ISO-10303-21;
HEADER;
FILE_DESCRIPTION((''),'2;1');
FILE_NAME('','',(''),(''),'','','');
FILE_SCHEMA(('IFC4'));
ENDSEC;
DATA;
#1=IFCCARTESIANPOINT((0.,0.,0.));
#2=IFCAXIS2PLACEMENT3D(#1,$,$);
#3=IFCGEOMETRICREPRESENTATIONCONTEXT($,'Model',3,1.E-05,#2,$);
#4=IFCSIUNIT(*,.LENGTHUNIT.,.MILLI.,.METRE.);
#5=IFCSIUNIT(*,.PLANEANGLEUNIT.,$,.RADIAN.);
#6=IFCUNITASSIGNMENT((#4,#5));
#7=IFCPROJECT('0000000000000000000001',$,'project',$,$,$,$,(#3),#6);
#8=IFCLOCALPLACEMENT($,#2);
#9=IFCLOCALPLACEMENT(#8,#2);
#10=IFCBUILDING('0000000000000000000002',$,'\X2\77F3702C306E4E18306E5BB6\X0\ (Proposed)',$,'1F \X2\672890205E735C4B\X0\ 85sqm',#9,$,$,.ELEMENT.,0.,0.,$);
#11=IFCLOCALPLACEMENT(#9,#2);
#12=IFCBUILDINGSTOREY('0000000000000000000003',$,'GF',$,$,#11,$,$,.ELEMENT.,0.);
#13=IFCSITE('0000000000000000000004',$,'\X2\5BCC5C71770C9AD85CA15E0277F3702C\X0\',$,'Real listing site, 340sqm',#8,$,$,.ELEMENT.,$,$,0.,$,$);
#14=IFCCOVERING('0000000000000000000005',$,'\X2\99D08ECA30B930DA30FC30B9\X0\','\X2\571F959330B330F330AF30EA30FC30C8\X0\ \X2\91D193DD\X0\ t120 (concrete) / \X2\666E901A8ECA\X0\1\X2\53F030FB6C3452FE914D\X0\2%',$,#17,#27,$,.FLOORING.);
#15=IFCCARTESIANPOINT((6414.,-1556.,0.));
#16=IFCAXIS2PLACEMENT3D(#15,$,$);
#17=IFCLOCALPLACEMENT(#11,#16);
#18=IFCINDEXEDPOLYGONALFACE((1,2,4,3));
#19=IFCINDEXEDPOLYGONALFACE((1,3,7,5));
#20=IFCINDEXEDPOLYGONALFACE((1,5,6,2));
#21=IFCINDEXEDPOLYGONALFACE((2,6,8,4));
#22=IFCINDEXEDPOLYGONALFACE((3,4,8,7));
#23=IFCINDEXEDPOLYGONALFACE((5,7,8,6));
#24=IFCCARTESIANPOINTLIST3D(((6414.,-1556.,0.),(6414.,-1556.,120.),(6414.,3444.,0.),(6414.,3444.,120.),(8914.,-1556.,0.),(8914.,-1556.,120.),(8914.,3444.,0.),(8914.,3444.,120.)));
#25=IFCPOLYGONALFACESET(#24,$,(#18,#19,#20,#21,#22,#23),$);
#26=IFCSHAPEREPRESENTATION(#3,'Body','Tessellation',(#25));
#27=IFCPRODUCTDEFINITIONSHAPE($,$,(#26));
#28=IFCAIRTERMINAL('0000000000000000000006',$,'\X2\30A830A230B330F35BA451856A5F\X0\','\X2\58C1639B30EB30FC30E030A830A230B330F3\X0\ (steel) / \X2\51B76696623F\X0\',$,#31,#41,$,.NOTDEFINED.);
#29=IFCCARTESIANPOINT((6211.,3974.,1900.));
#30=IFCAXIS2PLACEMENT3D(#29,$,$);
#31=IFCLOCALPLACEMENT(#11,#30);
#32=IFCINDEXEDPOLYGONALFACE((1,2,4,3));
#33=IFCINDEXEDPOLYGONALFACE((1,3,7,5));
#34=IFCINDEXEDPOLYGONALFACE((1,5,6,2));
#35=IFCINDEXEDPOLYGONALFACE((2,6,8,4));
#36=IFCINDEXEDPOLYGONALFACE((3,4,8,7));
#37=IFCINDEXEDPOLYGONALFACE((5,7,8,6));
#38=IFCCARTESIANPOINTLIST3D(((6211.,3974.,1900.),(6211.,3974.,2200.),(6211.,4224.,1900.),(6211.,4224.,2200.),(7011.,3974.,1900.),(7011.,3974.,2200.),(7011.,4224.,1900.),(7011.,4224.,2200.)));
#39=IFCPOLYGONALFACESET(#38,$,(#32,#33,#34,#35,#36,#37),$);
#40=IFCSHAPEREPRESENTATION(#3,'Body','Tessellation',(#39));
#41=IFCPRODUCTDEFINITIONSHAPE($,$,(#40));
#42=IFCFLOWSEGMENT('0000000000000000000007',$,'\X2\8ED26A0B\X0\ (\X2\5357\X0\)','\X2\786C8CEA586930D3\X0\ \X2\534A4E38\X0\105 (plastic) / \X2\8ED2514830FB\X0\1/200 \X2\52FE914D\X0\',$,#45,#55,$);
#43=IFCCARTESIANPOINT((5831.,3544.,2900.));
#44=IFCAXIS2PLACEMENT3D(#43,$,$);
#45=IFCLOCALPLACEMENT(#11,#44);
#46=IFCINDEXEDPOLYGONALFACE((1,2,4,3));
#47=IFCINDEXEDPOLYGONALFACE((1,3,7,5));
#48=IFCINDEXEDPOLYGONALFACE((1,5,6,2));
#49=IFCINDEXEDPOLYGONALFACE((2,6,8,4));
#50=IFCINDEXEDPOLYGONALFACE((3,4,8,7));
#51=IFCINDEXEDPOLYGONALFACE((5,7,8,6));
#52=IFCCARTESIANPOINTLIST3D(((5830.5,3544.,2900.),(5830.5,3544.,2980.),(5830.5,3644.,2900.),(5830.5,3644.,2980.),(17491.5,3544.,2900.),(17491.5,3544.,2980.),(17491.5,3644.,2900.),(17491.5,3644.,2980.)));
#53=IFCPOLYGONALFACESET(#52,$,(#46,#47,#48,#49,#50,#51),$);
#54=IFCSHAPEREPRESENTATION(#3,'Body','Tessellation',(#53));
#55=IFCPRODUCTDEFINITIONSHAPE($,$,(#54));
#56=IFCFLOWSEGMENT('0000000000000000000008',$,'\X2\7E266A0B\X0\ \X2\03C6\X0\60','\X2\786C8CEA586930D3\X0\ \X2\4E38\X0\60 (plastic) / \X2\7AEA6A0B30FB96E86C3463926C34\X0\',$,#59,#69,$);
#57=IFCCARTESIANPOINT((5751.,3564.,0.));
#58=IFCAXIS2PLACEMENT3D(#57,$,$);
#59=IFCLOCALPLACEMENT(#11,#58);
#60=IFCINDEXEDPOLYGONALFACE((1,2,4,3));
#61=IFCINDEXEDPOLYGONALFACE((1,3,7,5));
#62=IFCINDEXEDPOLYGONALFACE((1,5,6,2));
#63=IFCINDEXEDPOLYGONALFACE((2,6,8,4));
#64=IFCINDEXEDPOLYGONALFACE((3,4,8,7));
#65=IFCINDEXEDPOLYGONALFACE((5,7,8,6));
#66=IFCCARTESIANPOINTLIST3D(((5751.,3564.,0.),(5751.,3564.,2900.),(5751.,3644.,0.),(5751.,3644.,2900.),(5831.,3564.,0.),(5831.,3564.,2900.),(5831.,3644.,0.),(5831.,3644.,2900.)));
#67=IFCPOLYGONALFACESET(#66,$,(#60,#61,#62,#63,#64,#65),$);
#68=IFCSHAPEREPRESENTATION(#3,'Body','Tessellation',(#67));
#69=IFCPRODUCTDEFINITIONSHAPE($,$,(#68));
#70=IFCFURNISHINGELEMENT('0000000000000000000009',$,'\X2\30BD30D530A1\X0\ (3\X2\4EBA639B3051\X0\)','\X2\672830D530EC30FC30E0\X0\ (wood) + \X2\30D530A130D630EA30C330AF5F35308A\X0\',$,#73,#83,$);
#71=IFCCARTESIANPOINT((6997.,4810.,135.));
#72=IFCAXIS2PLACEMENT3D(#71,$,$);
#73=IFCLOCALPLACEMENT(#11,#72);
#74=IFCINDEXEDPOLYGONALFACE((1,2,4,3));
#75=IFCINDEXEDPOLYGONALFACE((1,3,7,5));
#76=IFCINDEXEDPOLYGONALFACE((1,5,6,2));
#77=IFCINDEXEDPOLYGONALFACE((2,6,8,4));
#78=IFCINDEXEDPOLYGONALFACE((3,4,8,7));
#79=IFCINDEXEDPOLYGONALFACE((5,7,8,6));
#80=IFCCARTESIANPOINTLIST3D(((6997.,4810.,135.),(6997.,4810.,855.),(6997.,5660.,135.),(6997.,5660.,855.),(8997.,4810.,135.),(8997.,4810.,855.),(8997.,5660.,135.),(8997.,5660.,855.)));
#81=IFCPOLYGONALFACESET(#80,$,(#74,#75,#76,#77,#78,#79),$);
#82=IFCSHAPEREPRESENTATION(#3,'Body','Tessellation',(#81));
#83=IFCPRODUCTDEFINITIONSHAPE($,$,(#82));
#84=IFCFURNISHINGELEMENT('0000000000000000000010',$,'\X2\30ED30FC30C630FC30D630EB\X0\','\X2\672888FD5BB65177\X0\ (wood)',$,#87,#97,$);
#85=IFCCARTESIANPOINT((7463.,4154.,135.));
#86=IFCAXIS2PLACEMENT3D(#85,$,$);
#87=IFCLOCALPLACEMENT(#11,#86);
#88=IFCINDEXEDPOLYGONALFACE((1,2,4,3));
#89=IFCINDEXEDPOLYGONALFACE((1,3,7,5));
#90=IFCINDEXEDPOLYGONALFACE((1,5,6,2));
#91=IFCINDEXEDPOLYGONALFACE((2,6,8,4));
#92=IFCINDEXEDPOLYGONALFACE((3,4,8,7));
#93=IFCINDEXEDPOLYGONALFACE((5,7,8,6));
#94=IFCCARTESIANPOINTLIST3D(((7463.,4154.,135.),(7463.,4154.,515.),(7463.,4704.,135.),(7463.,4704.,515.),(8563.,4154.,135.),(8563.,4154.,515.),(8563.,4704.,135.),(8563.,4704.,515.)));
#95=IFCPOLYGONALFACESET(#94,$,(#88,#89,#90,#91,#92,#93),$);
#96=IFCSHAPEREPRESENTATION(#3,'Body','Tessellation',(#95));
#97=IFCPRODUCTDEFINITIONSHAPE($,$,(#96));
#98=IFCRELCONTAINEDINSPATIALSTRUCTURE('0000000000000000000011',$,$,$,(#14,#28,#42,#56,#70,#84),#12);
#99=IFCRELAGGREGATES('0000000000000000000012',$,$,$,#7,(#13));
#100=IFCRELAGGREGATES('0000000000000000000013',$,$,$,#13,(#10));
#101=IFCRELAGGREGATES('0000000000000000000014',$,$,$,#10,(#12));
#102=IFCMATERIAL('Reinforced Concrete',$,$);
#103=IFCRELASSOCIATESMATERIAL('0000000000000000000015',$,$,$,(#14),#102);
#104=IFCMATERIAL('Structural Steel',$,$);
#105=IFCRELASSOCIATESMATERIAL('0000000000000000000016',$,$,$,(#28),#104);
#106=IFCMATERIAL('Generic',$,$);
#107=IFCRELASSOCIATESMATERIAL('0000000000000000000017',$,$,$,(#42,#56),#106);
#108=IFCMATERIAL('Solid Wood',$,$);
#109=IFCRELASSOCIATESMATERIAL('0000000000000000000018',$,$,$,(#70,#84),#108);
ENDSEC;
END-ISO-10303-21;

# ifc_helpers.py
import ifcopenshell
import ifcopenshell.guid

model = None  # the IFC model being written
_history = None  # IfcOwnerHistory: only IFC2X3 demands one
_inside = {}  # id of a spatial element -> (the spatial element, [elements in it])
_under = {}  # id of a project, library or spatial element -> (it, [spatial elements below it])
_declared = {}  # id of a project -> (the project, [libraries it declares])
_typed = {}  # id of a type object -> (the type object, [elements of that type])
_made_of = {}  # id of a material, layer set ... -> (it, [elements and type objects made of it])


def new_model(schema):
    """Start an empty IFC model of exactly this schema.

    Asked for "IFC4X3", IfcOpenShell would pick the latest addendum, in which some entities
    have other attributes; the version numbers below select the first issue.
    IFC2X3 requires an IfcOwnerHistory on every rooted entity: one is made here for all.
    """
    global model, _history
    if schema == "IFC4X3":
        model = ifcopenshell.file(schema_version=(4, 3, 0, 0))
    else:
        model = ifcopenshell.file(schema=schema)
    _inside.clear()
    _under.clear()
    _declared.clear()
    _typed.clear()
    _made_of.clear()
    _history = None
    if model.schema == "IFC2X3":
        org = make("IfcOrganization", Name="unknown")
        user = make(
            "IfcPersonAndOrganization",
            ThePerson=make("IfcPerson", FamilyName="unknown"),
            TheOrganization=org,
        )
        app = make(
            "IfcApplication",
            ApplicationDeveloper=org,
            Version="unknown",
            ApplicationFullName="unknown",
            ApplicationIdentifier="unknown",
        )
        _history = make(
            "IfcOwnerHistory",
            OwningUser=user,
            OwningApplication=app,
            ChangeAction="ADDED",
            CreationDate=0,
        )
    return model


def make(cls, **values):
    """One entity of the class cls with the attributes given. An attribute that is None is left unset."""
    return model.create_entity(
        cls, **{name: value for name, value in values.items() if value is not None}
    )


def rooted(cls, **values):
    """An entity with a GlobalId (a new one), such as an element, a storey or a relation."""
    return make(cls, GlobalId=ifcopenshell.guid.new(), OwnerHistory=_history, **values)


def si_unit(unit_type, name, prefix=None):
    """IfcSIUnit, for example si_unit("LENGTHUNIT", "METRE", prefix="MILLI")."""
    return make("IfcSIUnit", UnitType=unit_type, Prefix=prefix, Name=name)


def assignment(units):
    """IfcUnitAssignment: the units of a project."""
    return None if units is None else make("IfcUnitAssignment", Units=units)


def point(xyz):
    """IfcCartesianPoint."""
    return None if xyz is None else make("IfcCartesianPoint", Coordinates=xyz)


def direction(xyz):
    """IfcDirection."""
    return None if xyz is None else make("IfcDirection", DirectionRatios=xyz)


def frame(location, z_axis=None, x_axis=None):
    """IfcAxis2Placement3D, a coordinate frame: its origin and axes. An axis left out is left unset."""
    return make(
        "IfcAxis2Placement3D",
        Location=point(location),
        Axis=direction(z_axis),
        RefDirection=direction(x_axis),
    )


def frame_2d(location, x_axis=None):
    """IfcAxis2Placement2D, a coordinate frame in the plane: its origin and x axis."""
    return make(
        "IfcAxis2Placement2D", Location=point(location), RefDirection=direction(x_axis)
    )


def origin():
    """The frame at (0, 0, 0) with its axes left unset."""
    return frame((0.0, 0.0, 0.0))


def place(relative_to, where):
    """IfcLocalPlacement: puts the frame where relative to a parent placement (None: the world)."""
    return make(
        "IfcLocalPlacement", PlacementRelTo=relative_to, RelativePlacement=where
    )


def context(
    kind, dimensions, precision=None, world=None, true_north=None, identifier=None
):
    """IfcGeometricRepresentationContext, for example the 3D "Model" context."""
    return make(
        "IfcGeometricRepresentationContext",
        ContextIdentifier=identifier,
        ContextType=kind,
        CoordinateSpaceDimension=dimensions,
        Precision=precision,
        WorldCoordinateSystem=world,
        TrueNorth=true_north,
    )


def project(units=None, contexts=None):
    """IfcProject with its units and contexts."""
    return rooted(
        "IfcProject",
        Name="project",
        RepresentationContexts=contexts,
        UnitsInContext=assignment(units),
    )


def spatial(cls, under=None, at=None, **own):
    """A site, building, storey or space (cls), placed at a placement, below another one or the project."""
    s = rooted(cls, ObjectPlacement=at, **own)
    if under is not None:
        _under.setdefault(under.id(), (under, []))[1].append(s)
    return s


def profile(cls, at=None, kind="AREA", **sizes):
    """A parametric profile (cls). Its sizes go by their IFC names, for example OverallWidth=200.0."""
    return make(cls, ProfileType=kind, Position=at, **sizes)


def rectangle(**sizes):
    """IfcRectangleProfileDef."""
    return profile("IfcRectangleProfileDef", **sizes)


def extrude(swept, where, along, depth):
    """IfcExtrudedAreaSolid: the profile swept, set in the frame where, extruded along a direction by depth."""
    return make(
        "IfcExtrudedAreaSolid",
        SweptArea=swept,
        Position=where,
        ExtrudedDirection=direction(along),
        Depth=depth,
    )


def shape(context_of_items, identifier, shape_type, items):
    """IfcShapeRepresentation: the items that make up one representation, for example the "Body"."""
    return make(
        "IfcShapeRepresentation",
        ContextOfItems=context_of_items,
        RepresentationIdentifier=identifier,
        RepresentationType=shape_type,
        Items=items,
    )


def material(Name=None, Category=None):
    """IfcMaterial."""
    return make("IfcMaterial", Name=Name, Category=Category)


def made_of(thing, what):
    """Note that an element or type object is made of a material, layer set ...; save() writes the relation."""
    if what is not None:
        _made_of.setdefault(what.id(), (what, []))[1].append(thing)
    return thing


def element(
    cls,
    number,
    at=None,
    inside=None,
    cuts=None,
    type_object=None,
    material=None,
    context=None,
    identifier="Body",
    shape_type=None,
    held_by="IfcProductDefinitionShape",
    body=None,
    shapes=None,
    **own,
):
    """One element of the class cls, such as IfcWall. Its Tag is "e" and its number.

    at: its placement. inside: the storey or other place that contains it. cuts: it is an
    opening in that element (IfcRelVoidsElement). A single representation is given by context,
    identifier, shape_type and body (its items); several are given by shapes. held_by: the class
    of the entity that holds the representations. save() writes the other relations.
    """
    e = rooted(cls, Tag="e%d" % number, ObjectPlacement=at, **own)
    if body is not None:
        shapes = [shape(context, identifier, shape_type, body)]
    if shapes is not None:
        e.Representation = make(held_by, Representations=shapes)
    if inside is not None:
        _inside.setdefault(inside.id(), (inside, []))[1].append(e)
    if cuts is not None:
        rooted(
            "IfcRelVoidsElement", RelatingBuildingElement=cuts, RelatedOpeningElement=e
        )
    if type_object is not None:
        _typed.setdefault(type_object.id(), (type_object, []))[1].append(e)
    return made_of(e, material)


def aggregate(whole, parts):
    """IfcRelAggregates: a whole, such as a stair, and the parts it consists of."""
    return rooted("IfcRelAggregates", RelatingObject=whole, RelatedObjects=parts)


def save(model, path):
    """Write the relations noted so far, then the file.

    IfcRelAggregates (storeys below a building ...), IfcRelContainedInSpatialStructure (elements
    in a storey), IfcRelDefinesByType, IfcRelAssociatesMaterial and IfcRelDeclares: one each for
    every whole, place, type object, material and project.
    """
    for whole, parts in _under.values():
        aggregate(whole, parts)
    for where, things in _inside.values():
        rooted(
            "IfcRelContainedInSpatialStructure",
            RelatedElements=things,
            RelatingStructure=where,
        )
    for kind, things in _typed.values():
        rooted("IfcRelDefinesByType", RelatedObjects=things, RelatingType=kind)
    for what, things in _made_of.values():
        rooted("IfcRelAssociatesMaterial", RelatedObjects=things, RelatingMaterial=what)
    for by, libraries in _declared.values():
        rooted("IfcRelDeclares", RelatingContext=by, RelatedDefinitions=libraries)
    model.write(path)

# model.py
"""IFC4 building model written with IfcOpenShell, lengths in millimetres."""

from ifc_helpers import new_model, si_unit, frame, frame_2d, origin, place, context, project, spatial, rectangle, extrude, material, element, save


model = new_model("IFC4")

# Units and contexts
model_context = context("Model", 3, precision=1e-05, world=origin())
ifc_project = project(units=[si_unit("LENGTHUNIT", "METRE", prefix="MILLI"), si_unit("PLANEANGLEUNIT", "RADIAN")], contexts=[model_context])

# Site, building, storey
site_placement = place(None, origin())
site = spatial("IfcSite", under=ifc_project, at=site_placement, Name="富山県高岡市石瀬", ObjectType="Real listing site, 340sqm", CompositionType="ELEMENT", RefElevation=0.0)
building_placement = place(site_placement, origin())
building = spatial("IfcBuilding", under=site, at=building_placement, Name="石瀬の丘の家 (Proposed)", ObjectType="1F 木造平屋 85sqm", CompositionType="ELEMENT", ElevationOfRefHeight=0.0, ElevationOfTerrain=0.0)
storey_placement = place(building_placement, origin())
storey = spatial("IfcBuildingStorey", under=building, at=storey_placement, Name="GF", CompositionType="ELEMENT", Elevation=0.0)

# Shared definitions
ifc_material_1 = material(Name="Solid Wood")

# Shared definitions
ifc_material_2 = material(Name="Reinforced Concrete")

# Shared definitions
ifc_material_3 = material(Name="Structural Steel")

# Covering
ifc_material_4 = material(Name="Generic")
covering_1_placement = place(storey_placement, frame((6414.0, -1556.0, 0.0)))
element("IfcCovering", 1, at=covering_1_placement, inside=storey, material=ifc_material_2, Name="駐車スペース", Description="土間コンクリート 金鏝 t120 (concrete) / 普通車1台・水勾配2%", PredefinedType="FLOORING", context=model_context, shape_type="SweptSolid", body=[
    extrude(rectangle(XDim=2500.0, YDim=5000.0, at=frame_2d((1250.0, 2500.0))), frame((6414.0, -1556.0, 0.0)), (0.0, 0.0, 1.0), 120.0),
])

# Air terminal
air_terminal_placement = place(storey_placement, frame((6211.0, 3974.0, 1900.0)))
element("IfcAirTerminal", 2, at=air_terminal_placement, inside=storey, material=ifc_material_3, Name="エアコン室内機", Description="壁掛ルームエアコン (steel) / 冷暖房", PredefinedType="NOTDEFINED", context=model_context, shape_type="SweptSolid", body=[
    extrude(rectangle(XDim=800.0, YDim=250.0, at=frame_2d((400.0, 125.0))), frame((6211.0, 3974.0, 1900.0)), (0.0, 0.0, 1.0), 300.0),
])

# Flow segments
flow_segment_1_placement = place(storey_placement, frame((5831.0, 3544.0, 2900.0)))
element("IfcFlowSegment", 3, at=flow_segment_1_placement, inside=storey, material=ifc_material_4, Name="軒樋 (南)", Description="硬質塩ビ 半丸105 (plastic) / 軒先・1/200 勾配", context=model_context, shape_type="SweptSolid", body=[
    extrude(rectangle(XDim=11661.0, YDim=100.0, at=frame_2d((5830.0, 50.0))), frame((5831.0, 3544.0, 2900.0)), (0.0, 0.0, 1.0), 80.0),
])
flow_segment_2_placement = place(storey_placement, frame((5751.0, 3564.0, 0.0)))
element("IfcFlowSegment", 4, at=flow_segment_2_placement, inside=storey, material=ifc_material_4, Name="縦樋 φ60", Description="硬質塩ビ 丸60 (plastic) / 竪樋・雨水排水", context=model_context, shape_type="SweptSolid", body=[
    extrude(rectangle(XDim=80.0, YDim=80.0, at=frame_2d((40.0, 40.0))), frame((5751.0, 3564.0, 0.0)), (0.0, 0.0, 1.0), 2900.0),
])

# Furnishing elements
furnishing_1_placement = place(storey_placement, frame((6997.0, 4810.0, 135.0)))
element("IfcFurnishingElement", 5, at=furnishing_1_placement, inside=storey, material=ifc_material_1, Name="ソファ (3人掛け)", Description="木フレーム (wood) + ファブリック張り", context=model_context, shape_type="SweptSolid", body=[
    extrude(rectangle(XDim=2000.0, YDim=850.0, at=frame_2d((1000.0, 425.0))), frame((6997.0, 4810.0, 135.0)), (0.0, 0.0, 1.0), 720.0),
])
furnishing_2_placement = place(storey_placement, frame((7463.0, 4154.0, 135.0)))
element("IfcFurnishingElement", 6, at=furnishing_2_placement, inside=storey, material=ifc_material_1, Name="ローテーブル", Description="木製家具 (wood)", context=model_context, shape_type="SweptSolid", body=[
    extrude(rectangle(XDim=1100.0, YDim=550.0, at=frame_2d((550.0, 275.0))), frame((7463.0, 4154.0, 135.0)), (0.0, 0.0, 1.0), 380.0),
])

save(model, "model.ifc")
